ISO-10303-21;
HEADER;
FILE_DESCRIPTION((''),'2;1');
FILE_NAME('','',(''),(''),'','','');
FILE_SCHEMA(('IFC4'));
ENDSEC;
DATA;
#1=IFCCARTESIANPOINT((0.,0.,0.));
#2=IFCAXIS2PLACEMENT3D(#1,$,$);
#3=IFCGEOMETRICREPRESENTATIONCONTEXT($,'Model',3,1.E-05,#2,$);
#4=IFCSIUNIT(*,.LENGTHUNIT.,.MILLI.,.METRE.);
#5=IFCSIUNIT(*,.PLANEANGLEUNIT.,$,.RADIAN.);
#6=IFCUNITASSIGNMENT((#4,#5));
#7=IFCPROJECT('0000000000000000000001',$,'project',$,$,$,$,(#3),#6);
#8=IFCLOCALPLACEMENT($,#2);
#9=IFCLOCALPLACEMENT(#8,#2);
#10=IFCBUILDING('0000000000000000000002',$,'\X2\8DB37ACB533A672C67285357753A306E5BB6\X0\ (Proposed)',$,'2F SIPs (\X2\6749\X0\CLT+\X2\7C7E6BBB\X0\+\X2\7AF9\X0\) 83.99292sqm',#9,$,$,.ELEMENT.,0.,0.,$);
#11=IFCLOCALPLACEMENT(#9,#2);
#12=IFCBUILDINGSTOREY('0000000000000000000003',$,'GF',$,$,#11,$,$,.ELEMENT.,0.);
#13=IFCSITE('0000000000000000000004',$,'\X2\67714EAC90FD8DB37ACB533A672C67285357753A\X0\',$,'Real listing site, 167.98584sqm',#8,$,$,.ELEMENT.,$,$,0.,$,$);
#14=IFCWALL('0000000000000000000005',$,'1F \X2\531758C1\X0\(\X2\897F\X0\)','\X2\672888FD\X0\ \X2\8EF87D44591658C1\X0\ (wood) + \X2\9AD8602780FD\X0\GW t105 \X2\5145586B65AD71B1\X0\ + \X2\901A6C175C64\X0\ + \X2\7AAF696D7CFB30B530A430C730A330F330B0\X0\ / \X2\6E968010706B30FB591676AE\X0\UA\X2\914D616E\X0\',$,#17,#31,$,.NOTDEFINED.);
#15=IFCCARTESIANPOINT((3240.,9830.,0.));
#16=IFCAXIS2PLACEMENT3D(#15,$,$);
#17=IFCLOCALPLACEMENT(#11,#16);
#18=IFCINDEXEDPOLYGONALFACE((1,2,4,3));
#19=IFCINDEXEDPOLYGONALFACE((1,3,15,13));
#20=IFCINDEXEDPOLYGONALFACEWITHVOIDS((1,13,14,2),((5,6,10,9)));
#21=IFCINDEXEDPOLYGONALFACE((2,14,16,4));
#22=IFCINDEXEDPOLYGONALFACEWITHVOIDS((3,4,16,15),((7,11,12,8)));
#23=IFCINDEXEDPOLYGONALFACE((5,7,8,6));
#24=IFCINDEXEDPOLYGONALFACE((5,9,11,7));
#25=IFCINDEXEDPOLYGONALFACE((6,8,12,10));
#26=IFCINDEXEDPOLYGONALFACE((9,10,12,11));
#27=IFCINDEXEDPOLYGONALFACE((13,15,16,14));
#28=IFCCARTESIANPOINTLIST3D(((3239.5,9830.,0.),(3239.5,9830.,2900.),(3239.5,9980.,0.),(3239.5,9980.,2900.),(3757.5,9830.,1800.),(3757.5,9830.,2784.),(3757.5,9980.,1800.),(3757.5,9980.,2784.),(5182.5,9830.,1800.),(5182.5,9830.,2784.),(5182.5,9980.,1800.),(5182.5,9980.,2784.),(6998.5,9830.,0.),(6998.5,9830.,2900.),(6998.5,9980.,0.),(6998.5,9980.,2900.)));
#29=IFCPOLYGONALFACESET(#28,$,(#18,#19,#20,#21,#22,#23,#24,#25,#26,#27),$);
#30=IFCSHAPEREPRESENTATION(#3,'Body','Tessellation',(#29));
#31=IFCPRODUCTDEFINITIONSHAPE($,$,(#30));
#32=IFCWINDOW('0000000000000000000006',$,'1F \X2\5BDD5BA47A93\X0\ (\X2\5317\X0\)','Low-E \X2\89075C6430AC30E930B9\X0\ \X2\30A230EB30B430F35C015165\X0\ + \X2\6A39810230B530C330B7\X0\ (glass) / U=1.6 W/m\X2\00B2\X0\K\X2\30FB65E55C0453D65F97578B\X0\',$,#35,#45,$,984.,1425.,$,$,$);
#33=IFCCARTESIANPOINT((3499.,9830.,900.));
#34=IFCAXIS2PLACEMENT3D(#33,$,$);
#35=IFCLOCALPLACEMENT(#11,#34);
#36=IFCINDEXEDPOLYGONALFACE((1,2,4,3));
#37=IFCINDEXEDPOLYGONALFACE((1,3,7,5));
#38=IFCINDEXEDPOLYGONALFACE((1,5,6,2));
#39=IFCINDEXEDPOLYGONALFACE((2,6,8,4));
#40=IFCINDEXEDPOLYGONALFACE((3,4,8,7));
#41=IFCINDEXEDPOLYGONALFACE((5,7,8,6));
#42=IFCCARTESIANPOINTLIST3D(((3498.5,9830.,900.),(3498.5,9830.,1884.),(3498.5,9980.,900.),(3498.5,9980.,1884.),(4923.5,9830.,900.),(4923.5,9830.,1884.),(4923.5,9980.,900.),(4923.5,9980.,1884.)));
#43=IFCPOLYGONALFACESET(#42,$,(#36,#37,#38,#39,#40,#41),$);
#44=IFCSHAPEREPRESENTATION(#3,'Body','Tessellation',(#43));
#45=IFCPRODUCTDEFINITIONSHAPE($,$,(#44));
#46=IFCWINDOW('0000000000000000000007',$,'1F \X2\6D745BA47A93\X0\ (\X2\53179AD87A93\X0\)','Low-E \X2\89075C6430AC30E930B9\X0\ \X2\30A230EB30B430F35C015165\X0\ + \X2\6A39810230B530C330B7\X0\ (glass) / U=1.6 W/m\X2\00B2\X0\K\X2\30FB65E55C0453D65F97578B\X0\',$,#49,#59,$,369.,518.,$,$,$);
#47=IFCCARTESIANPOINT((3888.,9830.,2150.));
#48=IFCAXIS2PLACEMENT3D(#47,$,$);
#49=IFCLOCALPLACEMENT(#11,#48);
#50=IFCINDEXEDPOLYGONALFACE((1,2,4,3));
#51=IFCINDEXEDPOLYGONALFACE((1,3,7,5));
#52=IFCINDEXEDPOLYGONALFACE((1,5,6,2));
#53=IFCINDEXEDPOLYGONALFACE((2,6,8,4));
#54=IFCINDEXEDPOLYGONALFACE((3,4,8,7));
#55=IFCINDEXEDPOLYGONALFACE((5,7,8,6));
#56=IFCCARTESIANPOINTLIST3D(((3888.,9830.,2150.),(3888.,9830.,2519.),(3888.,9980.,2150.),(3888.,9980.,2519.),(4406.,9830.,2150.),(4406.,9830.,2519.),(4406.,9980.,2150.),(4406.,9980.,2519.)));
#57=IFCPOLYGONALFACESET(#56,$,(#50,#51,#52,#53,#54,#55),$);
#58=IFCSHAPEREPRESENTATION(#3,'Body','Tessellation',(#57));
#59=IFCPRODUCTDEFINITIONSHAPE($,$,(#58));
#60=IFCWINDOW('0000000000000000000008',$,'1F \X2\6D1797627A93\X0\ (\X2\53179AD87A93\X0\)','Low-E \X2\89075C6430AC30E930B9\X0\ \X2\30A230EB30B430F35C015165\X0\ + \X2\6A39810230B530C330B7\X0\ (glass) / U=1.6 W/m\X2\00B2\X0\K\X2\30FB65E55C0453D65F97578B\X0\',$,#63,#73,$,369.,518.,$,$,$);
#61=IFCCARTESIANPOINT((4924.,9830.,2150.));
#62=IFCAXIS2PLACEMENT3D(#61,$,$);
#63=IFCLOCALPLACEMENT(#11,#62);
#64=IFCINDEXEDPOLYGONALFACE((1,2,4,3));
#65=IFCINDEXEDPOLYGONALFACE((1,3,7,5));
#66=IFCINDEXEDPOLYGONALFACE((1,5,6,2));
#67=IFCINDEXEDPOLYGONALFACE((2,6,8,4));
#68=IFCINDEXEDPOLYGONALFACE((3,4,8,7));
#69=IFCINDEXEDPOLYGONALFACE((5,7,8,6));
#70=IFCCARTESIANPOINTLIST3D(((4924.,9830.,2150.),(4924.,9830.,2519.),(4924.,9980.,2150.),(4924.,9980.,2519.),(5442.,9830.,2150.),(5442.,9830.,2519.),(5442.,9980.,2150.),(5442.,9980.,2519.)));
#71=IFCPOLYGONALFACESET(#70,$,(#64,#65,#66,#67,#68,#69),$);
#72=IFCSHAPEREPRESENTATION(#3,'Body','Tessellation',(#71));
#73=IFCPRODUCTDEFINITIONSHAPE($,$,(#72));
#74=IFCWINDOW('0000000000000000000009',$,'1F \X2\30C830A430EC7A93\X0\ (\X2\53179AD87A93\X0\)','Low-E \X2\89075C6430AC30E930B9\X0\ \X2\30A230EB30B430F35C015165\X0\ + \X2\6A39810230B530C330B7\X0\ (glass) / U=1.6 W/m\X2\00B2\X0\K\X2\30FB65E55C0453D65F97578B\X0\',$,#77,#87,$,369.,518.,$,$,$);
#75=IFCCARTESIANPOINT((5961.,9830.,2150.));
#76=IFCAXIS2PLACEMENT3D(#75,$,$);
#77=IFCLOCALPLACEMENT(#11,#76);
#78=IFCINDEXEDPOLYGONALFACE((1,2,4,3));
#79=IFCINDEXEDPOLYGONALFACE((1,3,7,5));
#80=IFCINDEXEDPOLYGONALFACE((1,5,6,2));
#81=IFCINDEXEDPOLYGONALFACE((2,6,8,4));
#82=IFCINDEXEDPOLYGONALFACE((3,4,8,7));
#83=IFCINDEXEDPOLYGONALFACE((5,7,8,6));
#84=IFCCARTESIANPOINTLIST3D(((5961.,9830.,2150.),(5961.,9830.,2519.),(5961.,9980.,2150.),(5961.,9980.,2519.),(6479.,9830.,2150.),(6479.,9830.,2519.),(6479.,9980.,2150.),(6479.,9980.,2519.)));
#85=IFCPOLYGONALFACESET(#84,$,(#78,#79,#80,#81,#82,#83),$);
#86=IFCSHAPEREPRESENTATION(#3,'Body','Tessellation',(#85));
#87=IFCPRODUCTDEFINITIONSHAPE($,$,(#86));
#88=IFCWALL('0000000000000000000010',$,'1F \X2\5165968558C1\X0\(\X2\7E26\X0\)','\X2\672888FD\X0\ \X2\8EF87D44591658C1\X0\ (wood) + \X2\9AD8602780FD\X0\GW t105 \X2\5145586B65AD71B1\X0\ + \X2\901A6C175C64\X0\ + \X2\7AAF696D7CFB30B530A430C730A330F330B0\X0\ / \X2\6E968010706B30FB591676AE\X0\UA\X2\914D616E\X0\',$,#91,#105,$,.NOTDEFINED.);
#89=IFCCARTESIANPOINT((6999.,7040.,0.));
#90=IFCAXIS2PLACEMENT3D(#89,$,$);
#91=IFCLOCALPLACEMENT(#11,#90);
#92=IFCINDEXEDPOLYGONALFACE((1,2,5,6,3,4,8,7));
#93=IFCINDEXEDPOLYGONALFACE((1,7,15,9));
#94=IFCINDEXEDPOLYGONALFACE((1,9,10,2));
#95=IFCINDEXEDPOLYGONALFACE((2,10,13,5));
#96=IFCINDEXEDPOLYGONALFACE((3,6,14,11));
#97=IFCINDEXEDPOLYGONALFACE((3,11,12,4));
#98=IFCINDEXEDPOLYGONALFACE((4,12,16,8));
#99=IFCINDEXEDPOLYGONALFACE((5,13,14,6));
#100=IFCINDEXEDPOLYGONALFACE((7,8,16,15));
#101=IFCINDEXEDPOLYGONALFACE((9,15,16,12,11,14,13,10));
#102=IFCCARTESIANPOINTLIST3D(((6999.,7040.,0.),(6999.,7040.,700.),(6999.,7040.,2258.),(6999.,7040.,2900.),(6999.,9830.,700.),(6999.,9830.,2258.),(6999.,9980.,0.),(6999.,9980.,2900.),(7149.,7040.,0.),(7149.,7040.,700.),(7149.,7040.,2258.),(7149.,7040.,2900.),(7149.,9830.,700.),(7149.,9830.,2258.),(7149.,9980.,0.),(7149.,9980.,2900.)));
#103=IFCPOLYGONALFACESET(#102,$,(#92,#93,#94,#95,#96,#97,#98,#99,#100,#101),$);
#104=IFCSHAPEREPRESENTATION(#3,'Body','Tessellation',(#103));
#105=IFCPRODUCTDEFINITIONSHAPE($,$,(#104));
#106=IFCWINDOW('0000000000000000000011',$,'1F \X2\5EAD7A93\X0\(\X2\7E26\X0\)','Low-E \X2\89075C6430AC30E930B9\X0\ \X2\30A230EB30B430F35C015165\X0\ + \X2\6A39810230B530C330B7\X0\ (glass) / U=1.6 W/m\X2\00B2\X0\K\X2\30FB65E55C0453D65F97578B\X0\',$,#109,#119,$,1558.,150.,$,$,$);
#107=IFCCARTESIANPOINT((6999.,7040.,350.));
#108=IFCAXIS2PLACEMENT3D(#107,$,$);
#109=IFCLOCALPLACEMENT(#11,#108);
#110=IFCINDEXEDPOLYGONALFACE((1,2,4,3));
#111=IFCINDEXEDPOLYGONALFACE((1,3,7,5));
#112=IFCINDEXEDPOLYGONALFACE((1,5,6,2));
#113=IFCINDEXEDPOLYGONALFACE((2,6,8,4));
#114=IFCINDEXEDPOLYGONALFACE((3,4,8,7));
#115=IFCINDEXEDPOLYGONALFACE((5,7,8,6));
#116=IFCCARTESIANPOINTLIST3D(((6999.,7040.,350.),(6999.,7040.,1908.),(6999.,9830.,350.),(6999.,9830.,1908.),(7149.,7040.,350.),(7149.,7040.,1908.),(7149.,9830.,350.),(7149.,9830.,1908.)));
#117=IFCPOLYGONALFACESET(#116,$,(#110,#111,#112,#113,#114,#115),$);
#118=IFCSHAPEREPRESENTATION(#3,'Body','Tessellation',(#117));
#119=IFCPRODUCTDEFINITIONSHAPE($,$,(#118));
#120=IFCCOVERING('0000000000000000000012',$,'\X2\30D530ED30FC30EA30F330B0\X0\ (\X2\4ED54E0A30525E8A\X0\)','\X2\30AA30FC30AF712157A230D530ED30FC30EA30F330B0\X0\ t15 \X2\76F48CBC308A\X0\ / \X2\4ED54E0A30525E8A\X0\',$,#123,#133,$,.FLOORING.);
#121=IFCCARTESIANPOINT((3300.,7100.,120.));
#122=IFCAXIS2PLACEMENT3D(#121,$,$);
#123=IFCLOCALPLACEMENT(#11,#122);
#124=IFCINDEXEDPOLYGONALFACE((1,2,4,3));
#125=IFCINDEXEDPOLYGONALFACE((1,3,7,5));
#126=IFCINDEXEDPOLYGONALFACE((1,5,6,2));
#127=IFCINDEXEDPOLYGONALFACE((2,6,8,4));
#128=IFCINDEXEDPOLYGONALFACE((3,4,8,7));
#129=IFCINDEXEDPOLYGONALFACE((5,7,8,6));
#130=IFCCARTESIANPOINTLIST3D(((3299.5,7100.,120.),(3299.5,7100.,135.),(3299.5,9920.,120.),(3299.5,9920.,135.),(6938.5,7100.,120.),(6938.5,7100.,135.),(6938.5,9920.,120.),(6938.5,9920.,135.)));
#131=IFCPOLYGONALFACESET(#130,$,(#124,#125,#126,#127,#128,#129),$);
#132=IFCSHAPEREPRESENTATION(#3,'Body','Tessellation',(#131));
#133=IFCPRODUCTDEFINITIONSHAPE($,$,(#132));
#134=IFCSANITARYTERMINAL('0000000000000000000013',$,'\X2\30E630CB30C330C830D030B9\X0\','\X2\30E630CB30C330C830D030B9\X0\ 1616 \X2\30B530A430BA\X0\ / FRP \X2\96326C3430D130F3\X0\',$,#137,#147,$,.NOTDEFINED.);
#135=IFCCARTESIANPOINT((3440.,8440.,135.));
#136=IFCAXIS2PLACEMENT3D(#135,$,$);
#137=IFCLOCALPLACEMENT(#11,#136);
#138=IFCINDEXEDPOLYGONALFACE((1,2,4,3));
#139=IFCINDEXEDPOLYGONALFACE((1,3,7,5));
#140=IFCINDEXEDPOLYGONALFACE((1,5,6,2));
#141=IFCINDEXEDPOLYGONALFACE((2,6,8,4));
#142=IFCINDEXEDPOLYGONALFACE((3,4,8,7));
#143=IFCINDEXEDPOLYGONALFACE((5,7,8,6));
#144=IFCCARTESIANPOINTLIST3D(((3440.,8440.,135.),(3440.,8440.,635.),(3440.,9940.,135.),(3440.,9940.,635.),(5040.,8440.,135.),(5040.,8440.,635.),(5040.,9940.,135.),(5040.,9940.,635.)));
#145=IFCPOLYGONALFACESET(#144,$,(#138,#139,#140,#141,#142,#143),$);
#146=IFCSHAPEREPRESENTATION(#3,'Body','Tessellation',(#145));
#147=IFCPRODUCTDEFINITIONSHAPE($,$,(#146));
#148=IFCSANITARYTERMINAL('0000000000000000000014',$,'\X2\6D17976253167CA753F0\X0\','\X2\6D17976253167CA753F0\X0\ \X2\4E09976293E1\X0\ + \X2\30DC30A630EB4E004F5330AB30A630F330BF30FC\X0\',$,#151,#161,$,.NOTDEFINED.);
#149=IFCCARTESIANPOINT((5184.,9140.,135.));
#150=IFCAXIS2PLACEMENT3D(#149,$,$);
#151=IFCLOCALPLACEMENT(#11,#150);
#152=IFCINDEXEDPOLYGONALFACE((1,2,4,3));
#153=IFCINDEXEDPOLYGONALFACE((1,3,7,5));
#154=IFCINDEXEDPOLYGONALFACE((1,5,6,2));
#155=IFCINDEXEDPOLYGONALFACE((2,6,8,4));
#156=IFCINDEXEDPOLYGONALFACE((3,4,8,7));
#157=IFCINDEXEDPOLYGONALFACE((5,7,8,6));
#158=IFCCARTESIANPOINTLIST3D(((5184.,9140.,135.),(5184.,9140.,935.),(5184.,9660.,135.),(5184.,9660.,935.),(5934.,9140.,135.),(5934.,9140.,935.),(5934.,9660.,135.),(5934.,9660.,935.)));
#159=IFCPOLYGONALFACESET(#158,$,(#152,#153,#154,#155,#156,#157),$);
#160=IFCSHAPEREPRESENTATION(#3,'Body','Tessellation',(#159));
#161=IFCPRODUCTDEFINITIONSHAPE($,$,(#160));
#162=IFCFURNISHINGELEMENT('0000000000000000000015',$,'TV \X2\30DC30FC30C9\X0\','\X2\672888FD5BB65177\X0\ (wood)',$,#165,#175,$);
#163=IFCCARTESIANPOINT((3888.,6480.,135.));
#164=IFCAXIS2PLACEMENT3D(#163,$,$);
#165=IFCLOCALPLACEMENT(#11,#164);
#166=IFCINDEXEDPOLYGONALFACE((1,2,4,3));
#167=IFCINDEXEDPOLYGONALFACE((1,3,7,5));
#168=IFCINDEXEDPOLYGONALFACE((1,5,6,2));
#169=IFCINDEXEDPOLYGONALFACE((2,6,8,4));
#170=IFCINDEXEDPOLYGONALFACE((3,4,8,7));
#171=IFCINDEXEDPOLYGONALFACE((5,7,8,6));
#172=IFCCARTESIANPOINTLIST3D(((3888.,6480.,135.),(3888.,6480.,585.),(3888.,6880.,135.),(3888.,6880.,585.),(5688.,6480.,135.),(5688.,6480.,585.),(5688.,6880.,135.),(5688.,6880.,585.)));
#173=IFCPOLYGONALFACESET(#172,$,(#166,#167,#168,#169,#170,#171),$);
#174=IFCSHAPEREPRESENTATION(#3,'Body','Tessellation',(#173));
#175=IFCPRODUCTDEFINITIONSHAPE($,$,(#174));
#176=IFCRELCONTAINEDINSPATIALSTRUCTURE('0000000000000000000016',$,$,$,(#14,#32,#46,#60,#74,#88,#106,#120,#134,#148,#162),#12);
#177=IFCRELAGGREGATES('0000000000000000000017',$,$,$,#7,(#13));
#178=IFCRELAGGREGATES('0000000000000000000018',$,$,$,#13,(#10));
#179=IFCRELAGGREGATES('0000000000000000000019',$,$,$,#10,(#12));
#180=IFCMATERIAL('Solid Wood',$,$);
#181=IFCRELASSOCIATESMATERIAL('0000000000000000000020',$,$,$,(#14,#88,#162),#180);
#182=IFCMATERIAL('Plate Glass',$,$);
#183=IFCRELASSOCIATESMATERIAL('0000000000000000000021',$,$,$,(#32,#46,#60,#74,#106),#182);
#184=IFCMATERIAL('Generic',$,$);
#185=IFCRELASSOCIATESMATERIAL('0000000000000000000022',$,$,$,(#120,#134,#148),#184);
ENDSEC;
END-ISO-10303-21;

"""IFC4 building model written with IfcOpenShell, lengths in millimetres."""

from ifc_helpers import new_model, si_unit, frame, frame_2d, origin, place, context, project, spatial, rectangle, extrude, material, element, fill, save


model = new_model("IFC4")

# Units and contexts
model_context = context("Model", 3, precision=1e-05, world=origin())
ifc_project = project(units=[si_unit("LENGTHUNIT", "METRE", prefix="MILLI"), si_unit("PLANEANGLEUNIT", "RADIAN")], contexts=[model_context])

# Site, building, storey
site_placement = place(None, origin())
site = spatial("IfcSite", under=ifc_project, at=site_placement, Name="東京都足立区本木南町", ObjectType="Real listing site, 167.98584sqm", CompositionType="ELEMENT", RefElevation=0.0)
building_placement = place(site_placement, origin())
building = spatial("IfcBuilding", under=site, at=building_placement, Name="足立区本木南町の家 (Proposed)", ObjectType="2F SIPs (杉CLT+籾殻+竹) 83.99292sqm", CompositionType="ELEMENT", ElevationOfRefHeight=0.0, ElevationOfTerrain=0.0)
storey_placement = place(building_placement, origin())
storey = spatial("IfcBuildingStorey", under=building, at=storey_placement, Name="GF", CompositionType="ELEMENT", Elevation=0.0)

# Shared definitions
ifc_material_1 = material(Name="Solid Wood")

# Wall, openings, windows
wall_1_placement = place(storey_placement, frame((3240.0, 9830.0, 0.0)))
wall_1 = element("IfcWall", 1, at=wall_1_placement, inside=storey, material=ifc_material_1, Name="1F 北壁(西)", Description="木製 軸組外壁 (wood) + 高性能GW t105 充填断熱 + 通気層 + 窯業系サイディング / 準耐火・外皮UA配慮", PredefinedType="NOTDEFINED", context=model_context, shape_type="SweptSolid", body=[
    extrude(rectangle(XDim=3759.0, YDim=150.0, at=frame_2d((1879.0, 75.0))), frame((3240.0, 9830.0, 0.0)), (0.0, 0.0, 1.0), 2900.0),
])
opening_1_placement = place(storey_placement, frame((3499.0, 9830.0, 900.0)))
opening_1 = element("IfcOpeningElement", 2, at=opening_1_placement, cuts=wall_1, PredefinedType="NOTDEFINED", context=model_context, shape_type="SweptSolid", body=[
    extrude(rectangle(XDim=1425.0, YDim=150.0, at=frame_2d((712.0, 75.0))), frame((3499.0, 9830.0, 900.0)), (0.0, 0.0, 1.0), 984.0),
])
opening_2_placement = place(storey_placement, frame((3888.0, 9830.0, 2150.0)))
opening_2 = element("IfcOpeningElement", 3, at=opening_2_placement, cuts=wall_1, PredefinedType="NOTDEFINED", context=model_context, shape_type="SweptSolid", body=[
    extrude(rectangle(XDim=518.0, YDim=150.0, at=frame_2d((259.0, 75.0))), frame((3888.0, 9830.0, 2150.0)), (0.0, 0.0, 1.0), 369.0),
])
opening_3_placement = place(storey_placement, frame((4924.0, 9830.0, 2150.0)))
opening_3 = element("IfcOpeningElement", 4, at=opening_3_placement, cuts=wall_1, PredefinedType="NOTDEFINED", context=model_context, shape_type="SweptSolid", body=[
    extrude(rectangle(XDim=518.0, YDim=150.0, at=frame_2d((259.0, 75.0))), frame((4924.0, 9830.0, 2150.0)), (0.0, 0.0, 1.0), 369.0),
])
opening_4_placement = place(storey_placement, frame((5961.0, 9830.0, 2150.0)))
opening_4 = element("IfcOpeningElement", 5, at=opening_4_placement, cuts=wall_1, PredefinedType="NOTDEFINED", context=model_context, shape_type="SweptSolid", body=[
    extrude(rectangle(XDim=518.0, YDim=150.0, at=frame_2d((259.0, 75.0))), frame((5961.0, 9830.0, 2150.0)), (0.0, 0.0, 1.0), 369.0),
])
ifc_material_2 = material(Name="Plate Glass")
window_1_placement = place(storey_placement, frame((3499.0, 9830.0, 900.0)))
window_1 = element("IfcWindow", 6, at=window_1_placement, inside=storey, material=ifc_material_2, Name="1F 寝室窓 (北)", Description="Low-E 複層ガラス アルゴン封入 + 樹脂サッシ (glass) / U=1.6 W/m²K・日射取得型", OverallHeight=984.0, OverallWidth=1425.0, context=model_context, shape_type="SweptSolid", body=[
    extrude(rectangle(XDim=1425.0, YDim=150.0, at=frame_2d((712.0, 75.0))), frame((3499.0, 9830.0, 900.0)), (0.0, 0.0, 1.0), 984.0),
])
fill(opening_1, window_1)
window_2_placement = place(storey_placement, frame((3888.0, 9830.0, 2150.0)))
window_2 = element("IfcWindow", 7, at=window_2_placement, inside=storey, material=ifc_material_2, Name="1F 浴室窓 (北高窓)", Description="Low-E 複層ガラス アルゴン封入 + 樹脂サッシ (glass) / U=1.6 W/m²K・日射取得型", OverallHeight=369.0, OverallWidth=518.0, context=model_context, shape_type="SweptSolid", body=[
    extrude(rectangle(XDim=518.0, YDim=150.0, at=frame_2d((259.0, 75.0))), frame((3888.0, 9830.0, 2150.0)), (0.0, 0.0, 1.0), 369.0),
])
fill(opening_2, window_2)
window_3_placement = place(storey_placement, frame((4924.0, 9830.0, 2150.0)))
window_3 = element("IfcWindow", 8, at=window_3_placement, inside=storey, material=ifc_material_2, Name="1F 洗面窓 (北高窓)", Description="Low-E 複層ガラス アルゴン封入 + 樹脂サッシ (glass) / U=1.6 W/m²K・日射取得型", OverallHeight=369.0, OverallWidth=518.0, context=model_context, shape_type="SweptSolid", body=[
    extrude(rectangle(XDim=518.0, YDim=150.0, at=frame_2d((259.0, 75.0))), frame((4924.0, 9830.0, 2150.0)), (0.0, 0.0, 1.0), 369.0),
])
fill(opening_3, window_3)
window_4_placement = place(storey_placement, frame((5961.0, 9830.0, 2150.0)))
window_4 = element("IfcWindow", 9, at=window_4_placement, inside=storey, material=ifc_material_2, Name="1F トイレ窓 (北高窓)", Description="Low-E 複層ガラス アルゴン封入 + 樹脂サッシ (glass) / U=1.6 W/m²K・日射取得型", OverallHeight=369.0, OverallWidth=518.0, context=model_context, shape_type="SweptSolid", body=[
    extrude(rectangle(XDim=518.0, YDim=150.0, at=frame_2d((259.0, 75.0))), frame((5961.0, 9830.0, 2150.0)), (0.0, 0.0, 1.0), 369.0),
])
fill(opening_4, window_4)

# Wall, opening, window
wall_2_placement = place(storey_placement, frame((6999.0, 7040.0, 0.0)))
wall_2 = element("IfcWall", 10, at=wall_2_placement, inside=storey, material=ifc_material_1, Name="1F 入隅壁(縦)", Description="木製 軸組外壁 (wood) + 高性能GW t105 充填断熱 + 通気層 + 窯業系サイディング / 準耐火・外皮UA配慮", PredefinedType="NOTDEFINED", context=model_context, shape_type="SweptSolid", body=[
    extrude(rectangle(XDim=150.0, YDim=2940.0, at=frame_2d((75.0, 1470.0))), frame((6999.0, 7040.0, 0.0)), (0.0, 0.0, 1.0), 2900.0),
])
opening_5_placement = place(storey_placement, frame((6999.0, 7040.0, 350.0)))
opening_5 = element("IfcOpeningElement", 11, at=opening_5_placement, cuts=wall_2, PredefinedType="NOTDEFINED", context=model_context, shape_type="SweptSolid", body=[
    extrude(rectangle(XDim=150.0, YDim=2790.0, at=frame_2d((75.0, 1395.0))), frame((6999.0, 7040.0, 350.0)), (0.0, 0.0, 1.0), 1558.0),
])
window_5_placement = place(storey_placement, frame((6999.0, 7040.0, 350.0)))
window_5 = element("IfcWindow", 12, at=window_5_placement, inside=storey, material=ifc_material_2, Name="1F 庭窓(縦)", Description="Low-E 複層ガラス アルゴン封入 + 樹脂サッシ (glass) / U=1.6 W/m²K・日射取得型", OverallHeight=1558.0, OverallWidth=150.0, context=model_context, shape_type="SweptSolid", body=[
    extrude(rectangle(XDim=150.0, YDim=2790.0, at=frame_2d((75.0, 1395.0))), frame((6999.0, 7040.0, 350.0)), (0.0, 0.0, 1.0), 1558.0),
])
fill(opening_5, window_5)

# Covering
ifc_material_3 = material(Name="Generic")
covering_placement = place(storey_placement, frame((3300.0, 7100.0, 120.0)))
element("IfcCovering", 13, at=covering_placement, inside=storey, material=ifc_material_3, Name="フローリング (仕上げ床)", Description="オーク無垢フローリング t15 直貼り / 仕上げ床", PredefinedType="FLOORING", context=model_context, shape_type="SweptSolid", body=[
    extrude(rectangle(XDim=3639.0, YDim=2820.0, at=frame_2d((1819.0, 1410.0))), frame((3300.0, 7100.0, 120.0)), (0.0, 0.0, 1.0), 15.0),
])

# Sanitary terminals
sanitary_terminal_1_placement = place(storey_placement, frame((3440.0, 8440.0, 135.0)))
element("IfcSanitaryTerminal", 14, at=sanitary_terminal_1_placement, inside=storey, material=ifc_material_3, Name="ユニットバス", Description="ユニットバス 1616 サイズ / FRP 防水パン", PredefinedType="NOTDEFINED", context=model_context, shape_type="SweptSolid", body=[
    extrude(rectangle(XDim=1600.0, YDim=1500.0, at=frame_2d((800.0, 750.0))), frame((3440.0, 8440.0, 135.0)), (0.0, 0.0, 1.0), 500.0),
])
sanitary_terminal_2_placement = place(storey_placement, frame((5184.0, 9140.0, 135.0)))
element("IfcSanitaryTerminal", 15, at=sanitary_terminal_2_placement, inside=storey, material=ifc_material_3, Name="洗面化粧台", Description="洗面化粧台 三面鏡 + ボウル一体カウンター", PredefinedType="NOTDEFINED", context=model_context, shape_type="SweptSolid", body=[
    extrude(rectangle(XDim=750.0, YDim=520.0, at=frame_2d((375.0, 260.0))), frame((5184.0, 9140.0, 135.0)), (0.0, 0.0, 1.0), 800.0),
])

# Furnishing element
furnishing_placement = place(storey_placement, frame((3888.0, 6480.0, 135.0)))
element("IfcFurnishingElement", 16, at=furnishing_placement, inside=storey, material=ifc_material_1, Name="TV ボード", Description="木製家具 (wood)", context=model_context, shape_type="SweptSolid", body=[
    extrude(rectangle(XDim=1800.0, YDim=400.0, at=frame_2d((900.0, 200.0))), frame((3888.0, 6480.0, 135.0)), (0.0, 0.0, 1.0), 450.0),
])

save(model, "model.ifc")
